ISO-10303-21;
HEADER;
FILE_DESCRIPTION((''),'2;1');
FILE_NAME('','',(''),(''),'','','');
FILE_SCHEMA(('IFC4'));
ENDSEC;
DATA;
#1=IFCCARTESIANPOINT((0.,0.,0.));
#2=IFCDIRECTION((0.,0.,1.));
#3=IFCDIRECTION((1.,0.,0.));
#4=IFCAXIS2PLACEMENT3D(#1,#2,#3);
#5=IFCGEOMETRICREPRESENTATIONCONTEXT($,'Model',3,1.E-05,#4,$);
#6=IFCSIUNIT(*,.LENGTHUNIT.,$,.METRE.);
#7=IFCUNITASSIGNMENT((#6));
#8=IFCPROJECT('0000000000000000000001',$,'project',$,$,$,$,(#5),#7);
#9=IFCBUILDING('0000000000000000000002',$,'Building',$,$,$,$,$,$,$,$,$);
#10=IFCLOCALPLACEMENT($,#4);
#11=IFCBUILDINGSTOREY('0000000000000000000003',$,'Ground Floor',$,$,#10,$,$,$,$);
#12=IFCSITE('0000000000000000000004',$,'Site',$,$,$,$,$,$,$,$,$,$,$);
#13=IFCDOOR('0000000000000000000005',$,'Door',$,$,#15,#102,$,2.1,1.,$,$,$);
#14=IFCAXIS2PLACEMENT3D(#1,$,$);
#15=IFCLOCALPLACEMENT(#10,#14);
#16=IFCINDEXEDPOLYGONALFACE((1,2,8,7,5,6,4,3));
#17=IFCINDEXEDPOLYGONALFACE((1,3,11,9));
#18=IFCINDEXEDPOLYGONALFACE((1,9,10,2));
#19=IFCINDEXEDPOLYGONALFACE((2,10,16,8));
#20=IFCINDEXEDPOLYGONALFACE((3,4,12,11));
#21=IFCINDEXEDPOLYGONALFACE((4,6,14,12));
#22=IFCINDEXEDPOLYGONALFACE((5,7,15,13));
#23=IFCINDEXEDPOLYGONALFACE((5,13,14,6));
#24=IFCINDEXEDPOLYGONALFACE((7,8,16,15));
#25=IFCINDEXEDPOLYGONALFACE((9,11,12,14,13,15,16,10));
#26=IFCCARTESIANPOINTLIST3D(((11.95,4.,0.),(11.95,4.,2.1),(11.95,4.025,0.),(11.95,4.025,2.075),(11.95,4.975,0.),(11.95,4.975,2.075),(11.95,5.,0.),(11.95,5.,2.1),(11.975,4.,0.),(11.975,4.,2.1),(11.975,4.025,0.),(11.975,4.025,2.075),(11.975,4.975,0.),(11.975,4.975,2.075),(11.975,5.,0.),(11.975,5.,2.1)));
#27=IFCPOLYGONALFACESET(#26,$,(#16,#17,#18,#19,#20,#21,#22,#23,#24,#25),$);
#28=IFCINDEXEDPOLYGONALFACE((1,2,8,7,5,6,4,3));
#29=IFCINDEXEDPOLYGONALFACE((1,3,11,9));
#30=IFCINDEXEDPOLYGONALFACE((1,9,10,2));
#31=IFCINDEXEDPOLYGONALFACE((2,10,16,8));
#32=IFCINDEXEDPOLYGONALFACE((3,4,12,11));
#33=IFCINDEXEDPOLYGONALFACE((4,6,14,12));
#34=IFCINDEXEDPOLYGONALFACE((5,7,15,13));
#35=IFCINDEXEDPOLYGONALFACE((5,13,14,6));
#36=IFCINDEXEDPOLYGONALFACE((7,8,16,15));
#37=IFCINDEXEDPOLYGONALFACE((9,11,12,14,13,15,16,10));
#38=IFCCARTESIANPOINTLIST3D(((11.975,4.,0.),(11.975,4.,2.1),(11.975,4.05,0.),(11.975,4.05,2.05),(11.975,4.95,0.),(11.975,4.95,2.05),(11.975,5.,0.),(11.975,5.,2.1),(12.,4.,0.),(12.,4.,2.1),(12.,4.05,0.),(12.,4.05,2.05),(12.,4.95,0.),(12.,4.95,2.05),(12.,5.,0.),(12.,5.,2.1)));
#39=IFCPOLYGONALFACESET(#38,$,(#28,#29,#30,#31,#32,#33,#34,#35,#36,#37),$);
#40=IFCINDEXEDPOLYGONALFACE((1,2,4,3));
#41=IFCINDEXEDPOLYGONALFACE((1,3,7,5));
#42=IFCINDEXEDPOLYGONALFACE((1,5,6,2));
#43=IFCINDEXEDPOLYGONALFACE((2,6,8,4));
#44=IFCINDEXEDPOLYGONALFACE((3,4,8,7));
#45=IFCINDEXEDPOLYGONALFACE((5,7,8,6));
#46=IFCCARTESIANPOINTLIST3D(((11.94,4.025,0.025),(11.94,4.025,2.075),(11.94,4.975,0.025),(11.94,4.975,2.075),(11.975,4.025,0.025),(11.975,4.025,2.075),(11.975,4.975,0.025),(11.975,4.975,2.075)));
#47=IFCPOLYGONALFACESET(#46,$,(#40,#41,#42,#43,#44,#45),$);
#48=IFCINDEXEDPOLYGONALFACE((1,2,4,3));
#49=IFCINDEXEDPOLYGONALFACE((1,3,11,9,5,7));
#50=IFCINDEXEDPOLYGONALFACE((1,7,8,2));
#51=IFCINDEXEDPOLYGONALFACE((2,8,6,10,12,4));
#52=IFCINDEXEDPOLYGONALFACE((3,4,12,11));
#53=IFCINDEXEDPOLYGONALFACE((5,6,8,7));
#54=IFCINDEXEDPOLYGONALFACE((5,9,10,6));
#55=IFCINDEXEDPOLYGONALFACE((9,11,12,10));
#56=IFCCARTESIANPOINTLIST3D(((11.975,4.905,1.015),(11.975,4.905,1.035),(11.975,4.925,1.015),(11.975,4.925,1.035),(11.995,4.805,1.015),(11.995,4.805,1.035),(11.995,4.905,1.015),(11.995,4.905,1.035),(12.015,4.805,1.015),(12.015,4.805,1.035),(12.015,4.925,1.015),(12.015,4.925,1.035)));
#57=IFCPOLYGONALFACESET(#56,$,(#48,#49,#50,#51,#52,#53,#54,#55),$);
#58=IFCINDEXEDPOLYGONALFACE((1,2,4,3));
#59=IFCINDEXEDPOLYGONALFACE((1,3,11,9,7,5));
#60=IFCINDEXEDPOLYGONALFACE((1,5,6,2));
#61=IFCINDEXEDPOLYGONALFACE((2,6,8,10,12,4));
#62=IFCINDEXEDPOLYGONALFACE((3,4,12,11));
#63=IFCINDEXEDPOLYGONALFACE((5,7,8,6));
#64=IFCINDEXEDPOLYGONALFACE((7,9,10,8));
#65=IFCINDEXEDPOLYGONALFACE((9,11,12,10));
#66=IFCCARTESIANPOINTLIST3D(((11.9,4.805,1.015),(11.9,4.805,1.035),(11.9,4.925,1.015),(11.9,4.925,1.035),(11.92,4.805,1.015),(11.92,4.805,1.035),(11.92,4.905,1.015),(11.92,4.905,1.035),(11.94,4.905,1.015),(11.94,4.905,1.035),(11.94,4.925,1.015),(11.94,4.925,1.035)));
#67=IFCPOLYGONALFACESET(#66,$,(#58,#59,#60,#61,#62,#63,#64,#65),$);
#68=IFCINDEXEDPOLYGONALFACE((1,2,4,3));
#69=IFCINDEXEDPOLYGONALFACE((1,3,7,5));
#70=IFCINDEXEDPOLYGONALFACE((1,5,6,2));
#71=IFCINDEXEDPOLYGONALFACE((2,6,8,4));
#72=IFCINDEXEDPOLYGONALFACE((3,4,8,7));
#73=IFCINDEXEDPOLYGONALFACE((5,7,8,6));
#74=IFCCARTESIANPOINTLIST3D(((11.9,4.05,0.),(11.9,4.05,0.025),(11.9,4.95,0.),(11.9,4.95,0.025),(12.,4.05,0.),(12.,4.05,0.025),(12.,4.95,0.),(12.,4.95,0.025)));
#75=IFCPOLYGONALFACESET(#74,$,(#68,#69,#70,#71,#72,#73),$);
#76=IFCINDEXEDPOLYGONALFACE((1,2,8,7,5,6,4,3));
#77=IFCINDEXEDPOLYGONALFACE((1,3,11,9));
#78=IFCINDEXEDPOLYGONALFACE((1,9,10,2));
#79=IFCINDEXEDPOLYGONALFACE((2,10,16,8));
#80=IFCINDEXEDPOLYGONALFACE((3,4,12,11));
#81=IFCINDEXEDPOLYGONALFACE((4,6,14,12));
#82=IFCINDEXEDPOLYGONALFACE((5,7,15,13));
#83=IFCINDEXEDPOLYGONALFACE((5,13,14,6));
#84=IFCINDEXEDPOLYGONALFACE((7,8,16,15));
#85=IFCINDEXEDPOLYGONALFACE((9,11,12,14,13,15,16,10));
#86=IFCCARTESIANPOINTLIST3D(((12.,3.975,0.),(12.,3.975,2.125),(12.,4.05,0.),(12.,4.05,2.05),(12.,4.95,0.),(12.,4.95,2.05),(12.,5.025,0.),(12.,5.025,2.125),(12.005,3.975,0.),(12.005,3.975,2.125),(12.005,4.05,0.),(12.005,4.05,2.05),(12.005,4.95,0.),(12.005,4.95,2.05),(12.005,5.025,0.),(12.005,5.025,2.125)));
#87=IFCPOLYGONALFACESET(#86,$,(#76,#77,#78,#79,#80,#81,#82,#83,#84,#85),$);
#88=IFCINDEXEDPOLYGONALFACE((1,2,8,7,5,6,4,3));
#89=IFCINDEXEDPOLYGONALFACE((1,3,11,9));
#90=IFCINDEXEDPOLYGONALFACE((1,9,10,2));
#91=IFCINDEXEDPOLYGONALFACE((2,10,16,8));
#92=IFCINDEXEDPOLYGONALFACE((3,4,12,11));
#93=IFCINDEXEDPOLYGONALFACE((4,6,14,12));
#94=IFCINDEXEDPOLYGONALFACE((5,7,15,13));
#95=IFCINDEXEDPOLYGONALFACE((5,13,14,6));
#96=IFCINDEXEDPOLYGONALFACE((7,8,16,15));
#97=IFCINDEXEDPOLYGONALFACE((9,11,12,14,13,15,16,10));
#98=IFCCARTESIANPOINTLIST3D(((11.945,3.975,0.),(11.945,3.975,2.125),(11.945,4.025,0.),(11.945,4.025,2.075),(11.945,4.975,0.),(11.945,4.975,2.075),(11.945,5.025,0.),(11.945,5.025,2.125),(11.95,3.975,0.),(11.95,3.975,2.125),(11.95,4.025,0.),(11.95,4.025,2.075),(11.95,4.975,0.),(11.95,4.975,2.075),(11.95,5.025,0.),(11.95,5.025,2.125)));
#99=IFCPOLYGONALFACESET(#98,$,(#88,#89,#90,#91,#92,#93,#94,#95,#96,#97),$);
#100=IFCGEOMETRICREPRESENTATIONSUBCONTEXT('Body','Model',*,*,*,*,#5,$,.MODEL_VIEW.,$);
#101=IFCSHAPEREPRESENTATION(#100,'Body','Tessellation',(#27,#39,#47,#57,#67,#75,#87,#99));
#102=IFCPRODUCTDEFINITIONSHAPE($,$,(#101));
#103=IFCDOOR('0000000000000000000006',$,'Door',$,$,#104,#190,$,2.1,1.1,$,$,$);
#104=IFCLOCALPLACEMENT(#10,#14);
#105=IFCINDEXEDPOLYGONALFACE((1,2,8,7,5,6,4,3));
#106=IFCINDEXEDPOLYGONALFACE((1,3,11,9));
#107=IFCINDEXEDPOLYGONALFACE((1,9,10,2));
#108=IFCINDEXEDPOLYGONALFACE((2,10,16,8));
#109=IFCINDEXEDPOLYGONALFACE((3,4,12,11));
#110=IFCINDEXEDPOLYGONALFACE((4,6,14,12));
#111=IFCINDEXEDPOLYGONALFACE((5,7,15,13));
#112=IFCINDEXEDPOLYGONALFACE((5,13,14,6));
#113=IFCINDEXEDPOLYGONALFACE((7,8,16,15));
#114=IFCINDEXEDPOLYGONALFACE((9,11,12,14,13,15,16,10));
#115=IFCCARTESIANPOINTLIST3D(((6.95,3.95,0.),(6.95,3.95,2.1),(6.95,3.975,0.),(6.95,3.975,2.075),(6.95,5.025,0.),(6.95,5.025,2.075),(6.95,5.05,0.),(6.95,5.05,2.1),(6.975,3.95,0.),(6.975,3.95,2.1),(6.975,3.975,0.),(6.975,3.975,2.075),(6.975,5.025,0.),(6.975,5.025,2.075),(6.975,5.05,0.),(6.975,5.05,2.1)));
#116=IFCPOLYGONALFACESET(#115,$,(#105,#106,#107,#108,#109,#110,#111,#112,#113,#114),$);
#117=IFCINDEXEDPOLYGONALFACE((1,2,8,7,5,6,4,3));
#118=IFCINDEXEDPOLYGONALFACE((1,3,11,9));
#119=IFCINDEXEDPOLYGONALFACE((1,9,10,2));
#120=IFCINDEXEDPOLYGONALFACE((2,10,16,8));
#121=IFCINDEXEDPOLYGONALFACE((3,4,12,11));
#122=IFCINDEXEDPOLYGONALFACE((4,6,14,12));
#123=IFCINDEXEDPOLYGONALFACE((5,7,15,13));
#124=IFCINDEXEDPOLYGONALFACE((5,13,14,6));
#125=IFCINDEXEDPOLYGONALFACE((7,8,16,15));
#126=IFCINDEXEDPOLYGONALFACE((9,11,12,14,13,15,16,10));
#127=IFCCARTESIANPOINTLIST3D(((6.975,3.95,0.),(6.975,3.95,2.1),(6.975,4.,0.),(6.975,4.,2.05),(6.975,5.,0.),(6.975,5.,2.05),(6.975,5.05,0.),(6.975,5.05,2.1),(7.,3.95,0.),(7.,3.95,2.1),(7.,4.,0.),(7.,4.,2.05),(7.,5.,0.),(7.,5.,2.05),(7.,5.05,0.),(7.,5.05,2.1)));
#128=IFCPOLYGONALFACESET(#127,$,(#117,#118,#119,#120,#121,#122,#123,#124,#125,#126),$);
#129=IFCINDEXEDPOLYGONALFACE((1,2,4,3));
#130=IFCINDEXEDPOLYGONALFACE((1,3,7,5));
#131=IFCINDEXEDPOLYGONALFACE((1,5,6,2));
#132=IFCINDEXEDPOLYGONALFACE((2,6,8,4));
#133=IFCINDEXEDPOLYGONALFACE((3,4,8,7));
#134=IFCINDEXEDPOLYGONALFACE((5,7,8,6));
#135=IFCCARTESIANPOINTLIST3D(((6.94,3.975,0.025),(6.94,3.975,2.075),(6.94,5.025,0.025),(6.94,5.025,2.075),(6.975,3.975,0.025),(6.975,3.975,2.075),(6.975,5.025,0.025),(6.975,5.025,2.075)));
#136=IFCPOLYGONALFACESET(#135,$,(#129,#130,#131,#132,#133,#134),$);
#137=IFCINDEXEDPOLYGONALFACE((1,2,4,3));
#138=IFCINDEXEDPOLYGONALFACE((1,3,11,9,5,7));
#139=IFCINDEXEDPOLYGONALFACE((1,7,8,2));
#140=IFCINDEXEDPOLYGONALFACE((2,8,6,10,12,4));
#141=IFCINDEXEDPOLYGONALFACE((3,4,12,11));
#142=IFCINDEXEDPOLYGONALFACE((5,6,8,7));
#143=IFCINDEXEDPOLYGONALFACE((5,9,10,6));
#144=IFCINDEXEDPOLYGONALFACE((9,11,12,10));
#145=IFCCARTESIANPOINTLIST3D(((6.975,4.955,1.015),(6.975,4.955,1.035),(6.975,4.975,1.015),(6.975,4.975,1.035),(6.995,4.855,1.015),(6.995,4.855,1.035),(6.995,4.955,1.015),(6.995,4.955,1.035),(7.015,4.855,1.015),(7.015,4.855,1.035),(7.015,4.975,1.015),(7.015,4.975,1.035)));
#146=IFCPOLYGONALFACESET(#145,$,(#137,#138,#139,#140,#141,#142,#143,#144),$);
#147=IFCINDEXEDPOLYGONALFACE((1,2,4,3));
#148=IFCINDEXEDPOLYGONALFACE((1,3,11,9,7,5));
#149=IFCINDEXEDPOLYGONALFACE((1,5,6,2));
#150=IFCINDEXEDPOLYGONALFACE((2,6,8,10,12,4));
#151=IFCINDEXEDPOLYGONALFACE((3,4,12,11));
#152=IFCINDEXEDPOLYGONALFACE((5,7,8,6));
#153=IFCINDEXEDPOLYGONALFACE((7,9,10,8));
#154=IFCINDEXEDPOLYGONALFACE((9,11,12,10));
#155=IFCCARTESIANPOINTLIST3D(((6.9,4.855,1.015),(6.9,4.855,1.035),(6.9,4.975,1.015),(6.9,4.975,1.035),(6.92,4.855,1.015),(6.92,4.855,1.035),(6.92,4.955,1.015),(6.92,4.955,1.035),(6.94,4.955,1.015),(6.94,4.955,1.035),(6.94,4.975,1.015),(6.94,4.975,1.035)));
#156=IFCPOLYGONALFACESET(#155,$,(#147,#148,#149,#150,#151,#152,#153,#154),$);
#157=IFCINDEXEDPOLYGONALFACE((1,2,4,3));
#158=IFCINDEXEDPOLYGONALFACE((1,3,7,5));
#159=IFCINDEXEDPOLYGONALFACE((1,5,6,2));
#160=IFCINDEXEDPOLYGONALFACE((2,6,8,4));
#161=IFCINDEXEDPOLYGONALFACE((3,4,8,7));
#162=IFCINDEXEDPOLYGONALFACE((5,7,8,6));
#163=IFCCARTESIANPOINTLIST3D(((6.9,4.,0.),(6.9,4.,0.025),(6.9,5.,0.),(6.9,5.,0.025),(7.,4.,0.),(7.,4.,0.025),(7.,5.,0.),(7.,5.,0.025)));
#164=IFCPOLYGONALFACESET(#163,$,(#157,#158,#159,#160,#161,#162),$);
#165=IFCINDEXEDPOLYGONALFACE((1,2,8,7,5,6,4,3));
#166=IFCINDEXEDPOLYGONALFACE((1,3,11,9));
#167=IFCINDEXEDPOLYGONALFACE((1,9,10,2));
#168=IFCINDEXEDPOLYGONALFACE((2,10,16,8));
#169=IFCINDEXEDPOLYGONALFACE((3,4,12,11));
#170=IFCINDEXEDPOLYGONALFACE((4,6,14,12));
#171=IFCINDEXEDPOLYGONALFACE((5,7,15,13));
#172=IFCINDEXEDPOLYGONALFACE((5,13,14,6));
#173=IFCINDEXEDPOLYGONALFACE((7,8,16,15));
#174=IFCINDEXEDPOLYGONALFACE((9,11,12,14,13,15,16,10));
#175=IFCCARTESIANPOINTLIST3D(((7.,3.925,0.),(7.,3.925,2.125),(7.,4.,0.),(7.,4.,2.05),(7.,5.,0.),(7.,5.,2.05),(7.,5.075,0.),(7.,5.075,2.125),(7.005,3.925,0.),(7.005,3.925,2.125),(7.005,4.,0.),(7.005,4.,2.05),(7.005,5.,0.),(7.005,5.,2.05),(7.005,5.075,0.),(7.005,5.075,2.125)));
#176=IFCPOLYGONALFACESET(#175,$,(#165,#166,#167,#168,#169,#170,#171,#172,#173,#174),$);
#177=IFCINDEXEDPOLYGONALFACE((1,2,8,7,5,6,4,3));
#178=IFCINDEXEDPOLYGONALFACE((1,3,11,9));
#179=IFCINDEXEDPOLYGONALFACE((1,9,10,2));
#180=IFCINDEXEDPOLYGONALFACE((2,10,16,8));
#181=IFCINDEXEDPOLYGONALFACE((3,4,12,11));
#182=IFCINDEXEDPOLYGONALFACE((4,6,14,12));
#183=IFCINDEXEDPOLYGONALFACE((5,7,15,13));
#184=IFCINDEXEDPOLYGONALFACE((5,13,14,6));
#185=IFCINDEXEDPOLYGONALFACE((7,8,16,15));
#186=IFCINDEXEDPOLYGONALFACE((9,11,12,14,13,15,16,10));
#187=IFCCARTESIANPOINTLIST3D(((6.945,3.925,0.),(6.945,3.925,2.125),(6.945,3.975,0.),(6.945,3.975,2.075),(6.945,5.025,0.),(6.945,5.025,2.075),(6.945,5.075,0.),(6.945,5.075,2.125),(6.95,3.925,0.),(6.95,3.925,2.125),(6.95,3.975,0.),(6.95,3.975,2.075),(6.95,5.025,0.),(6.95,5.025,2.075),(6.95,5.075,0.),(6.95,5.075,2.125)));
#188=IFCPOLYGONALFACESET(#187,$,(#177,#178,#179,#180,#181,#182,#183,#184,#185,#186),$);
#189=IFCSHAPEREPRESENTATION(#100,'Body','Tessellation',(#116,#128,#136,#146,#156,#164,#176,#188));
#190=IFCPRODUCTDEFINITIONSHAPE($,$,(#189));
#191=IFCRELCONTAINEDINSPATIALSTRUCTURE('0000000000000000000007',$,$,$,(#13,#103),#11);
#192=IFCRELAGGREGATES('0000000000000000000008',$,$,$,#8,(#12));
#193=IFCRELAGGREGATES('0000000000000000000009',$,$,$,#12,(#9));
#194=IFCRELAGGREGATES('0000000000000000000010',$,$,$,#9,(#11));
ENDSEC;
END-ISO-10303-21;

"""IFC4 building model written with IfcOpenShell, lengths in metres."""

from ifc_helpers import new_model, si_unit, frame, origin_with_axes, place, context, subcontext, project, spatial, line, indexed_curve, outline, extrude, element, save


model = new_model("IFC4")

# Units and contexts
model_context = context("Model", 3, precision=1e-05, world=origin_with_axes())
body_context = subcontext(model_context, "Body", "Model", "MODEL_VIEW")
ifc_project = project(units=[si_unit("LENGTHUNIT", "METRE")], contexts=[model_context])

# Site, building, storey
site = spatial("IfcSite", under=ifc_project, Name="Site")
building = spatial("IfcBuilding", under=site, Name="Building")
storey_placement = place(None, origin_with_axes())
storey = spatial("IfcBuildingStorey", under=building, at=storey_placement, Name="Ground Floor")

# Doors
door_1_placement = place(storey_placement, frame((12.0, 4.0, 0.0), z_axis=(0.0, 0.0, 1.0), x_axis=(0.0, 1.0, 0.0)))
element("IfcDoor", 1, at=door_1_placement, inside=storey, Name="Door", OverallHeight=2.1, OverallWidth=1.0, context=body_context, shape_type="SweptSolid", body=[
    extrude(outline(indexed_curve([(0.0, 0.0), (0.0, 2.1), (1.0, 2.1), (1.0, 0.0), (0.975, 0.0), (0.975, 2.075), (0.025, 2.075), (0.025, 0.0)], segments=[line(1, 2, 3, 4, 5, 6, 7, 8, 1)])), frame((0.0, 0.025, 0.0), z_axis=(0.0, -1.0, 0.0), x_axis=(1.0, 0.0, 0.0)), (0.0, 0.0, -1.0), 0.025),
    extrude(outline(indexed_curve([(0.0, 0.0), (0.0, 2.1), (1.0, 2.1), (1.0, 0.0), (0.95, 0.0), (0.95, 2.05), (0.05, 2.05), (0.05, 0.0)], segments=[line(1, 2, 3, 4, 5, 6, 7, 8, 1)])), frame((0.0, 0.0, 0.0), z_axis=(0.0, -1.0, 0.0), x_axis=(1.0, 0.0, 0.0)), (0.0, 0.0, -1.0), 0.025),
    extrude(outline(indexed_curve([(0.0, 0.0), (0.95, 0.0), (0.95, 0.035), (0.0, 0.035)], segments=[line(1, 2, 3, 4, 1)])), frame((0.025, 0.025, 0.025), z_axis=(0.0, 0.0, 1.0), x_axis=(1.0, 0.0, 0.0)), (0.0, 0.0, 1.0), 2.05),
    extrude(outline(indexed_curve([(0.0, 0.0), (0.0, -0.04), (-0.12, -0.04), (-0.12, -0.02), (-0.02, -0.02), (-0.02, 0.0)], segments=[line(1, 2, 3, 4, 5, 6, 1)])), frame((0.925, 0.025, 1.015), z_axis=(0.0, 0.0, 1.0), x_axis=(1.0, 0.0, 0.0)), (0.0, 0.0, 1.0), 0.02),
    extrude(outline(indexed_curve([(0.0, 0.0), (0.0, 0.04), (-0.12, 0.04), (-0.12, 0.02), (-0.02, 0.02), (-0.02, 0.0)], segments=[line(1, 2, 3, 4, 5, 6, 1)])), frame((0.925, 0.06, 1.015), z_axis=(0.0, 0.0, 1.0), x_axis=(1.0, 0.0, 0.0)), (0.0, 0.0, 1.0), 0.02),
    extrude(outline(indexed_curve([(0.0, 0.0), (0.9, 0.0), (0.9, 0.1), (0.0, 0.1)], segments=[line(1, 2, 3, 4, 1)])), frame((0.05, 0.0, 0.0), z_axis=(0.0, 0.0, 1.0), x_axis=(1.0, 0.0, 0.0)), (0.0, 0.0, 1.0), 0.025),
    extrude(outline(indexed_curve([(0.0, 0.0), (0.0, 2.125), (1.05, 2.125), (1.05, 0.0), (0.975, 0.0), (0.975, 2.05), (0.075, 2.05), (0.075, 0.0)], segments=[line(1, 2, 3, 4, 5, 6, 7, 8, 1)])), frame((-0.025, -0.005, 0.0), z_axis=(0.0, -1.0, 0.0), x_axis=(1.0, 0.0, 0.0)), (0.0, 0.0, -1.0), 0.005),
    extrude(outline(indexed_curve([(0.0, 0.0), (0.0, 2.125), (1.05, 2.125), (1.05, 0.0), (1.0, 0.0), (1.0, 2.075), (0.05, 2.075), (0.05, 0.0)], segments=[line(1, 2, 3, 4, 5, 6, 7, 8, 1)])), frame((-0.025, 0.05, 0.0), z_axis=(0.0, -1.0, 0.0), x_axis=(1.0, 0.0, 0.0)), (0.0, 0.0, -1.0), 0.005),
])
door_2_placement = place(storey_placement, frame((7.0, 3.95, 0.0), z_axis=(0.0, 0.0, 1.0), x_axis=(0.0, 1.0, 0.0)))
element("IfcDoor", 2, at=door_2_placement, inside=storey, Name="Door", OverallHeight=2.1, OverallWidth=1.1, context=body_context, shape_type="SweptSolid", body=[
    extrude(outline(indexed_curve([(0.0, 0.0), (0.0, 2.1), (1.1, 2.1), (1.1, 0.0), (1.075, 0.0), (1.075, 2.075), (0.025, 2.075), (0.025, 0.0)], segments=[line(1, 2, 3, 4, 5, 6, 7, 8, 1)])), frame((0.0, 0.025, 0.0), z_axis=(0.0, -1.0, 0.0), x_axis=(1.0, 0.0, 0.0)), (0.0, 0.0, -1.0), 0.025),
    extrude(outline(indexed_curve([(0.0, 0.0), (0.0, 2.1), (1.1, 2.1), (1.1, 0.0), (1.05, 0.0), (1.05, 2.05), (0.05, 2.05), (0.05, 0.0)], segments=[line(1, 2, 3, 4, 5, 6, 7, 8, 1)])), frame((0.0, 0.0, 0.0), z_axis=(0.0, -1.0, 0.0), x_axis=(1.0, 0.0, 0.0)), (0.0, 0.0, -1.0), 0.025),
    extrude(outline(indexed_curve([(0.0, 0.0), (1.05, 0.0), (1.05, 0.035), (0.0, 0.035)], segments=[line(1, 2, 3, 4, 1)])), frame((0.025, 0.025, 0.025), z_axis=(0.0, 0.0, 1.0), x_axis=(1.0, 0.0, 0.0)), (0.0, 0.0, 1.0), 2.05),
    extrude(outline(indexed_curve([(0.0, 0.0), (0.0, -0.04), (-0.12, -0.04), (-0.12, -0.02), (-0.02, -0.02), (-0.02, 0.0)], segments=[line(1, 2, 3, 4, 5, 6, 1)])), frame((1.025, 0.025, 1.015), z_axis=(0.0, 0.0, 1.0), x_axis=(1.0, 0.0, 0.0)), (0.0, 0.0, 1.0), 0.02),
    extrude(outline(indexed_curve([(0.0, 0.0), (0.0, 0.04), (-0.12, 0.04), (-0.12, 0.02), (-0.02, 0.02), (-0.02, 0.0)], segments=[line(1, 2, 3, 4, 5, 6, 1)])), frame((1.025, 0.06, 1.015), z_axis=(0.0, 0.0, 1.0), x_axis=(1.0, 0.0, 0.0)), (0.0, 0.0, 1.0), 0.02),
    extrude(outline(indexed_curve([(0.0, 0.0), (1.0, 0.0), (1.0, 0.1), (0.0, 0.1)], segments=[line(1, 2, 3, 4, 1)])), frame((0.05, 0.0, 0.0), z_axis=(0.0, 0.0, 1.0), x_axis=(1.0, 0.0, 0.0)), (0.0, 0.0, 1.0), 0.025),
    extrude(outline(indexed_curve([(0.0, 0.0), (0.0, 2.125), (1.15, 2.125), (1.15, 0.0), (1.075, 0.0), (1.075, 2.05), (0.075, 2.05), (0.075, 0.0)], segments=[line(1, 2, 3, 4, 5, 6, 7, 8, 1)])), frame((-0.025, -0.005, 0.0), z_axis=(0.0, -1.0, 0.0), x_axis=(1.0, 0.0, 0.0)), (0.0, 0.0, -1.0), 0.005),
    extrude(outline(indexed_curve([(0.0, 0.0), (0.0, 2.125), (1.15, 2.125), (1.15, 0.0), (1.1, 0.0), (1.1, 2.075), (0.05, 2.075), (0.05, 0.0)], segments=[line(1, 2, 3, 4, 5, 6, 7, 8, 1)])), frame((-0.025, 0.05, 0.0), z_axis=(0.0, -1.0, 0.0), x_axis=(1.0, 0.0, 0.0)), (0.0, 0.0, -1.0), 0.005),
])

save(model, "model.ifc")
